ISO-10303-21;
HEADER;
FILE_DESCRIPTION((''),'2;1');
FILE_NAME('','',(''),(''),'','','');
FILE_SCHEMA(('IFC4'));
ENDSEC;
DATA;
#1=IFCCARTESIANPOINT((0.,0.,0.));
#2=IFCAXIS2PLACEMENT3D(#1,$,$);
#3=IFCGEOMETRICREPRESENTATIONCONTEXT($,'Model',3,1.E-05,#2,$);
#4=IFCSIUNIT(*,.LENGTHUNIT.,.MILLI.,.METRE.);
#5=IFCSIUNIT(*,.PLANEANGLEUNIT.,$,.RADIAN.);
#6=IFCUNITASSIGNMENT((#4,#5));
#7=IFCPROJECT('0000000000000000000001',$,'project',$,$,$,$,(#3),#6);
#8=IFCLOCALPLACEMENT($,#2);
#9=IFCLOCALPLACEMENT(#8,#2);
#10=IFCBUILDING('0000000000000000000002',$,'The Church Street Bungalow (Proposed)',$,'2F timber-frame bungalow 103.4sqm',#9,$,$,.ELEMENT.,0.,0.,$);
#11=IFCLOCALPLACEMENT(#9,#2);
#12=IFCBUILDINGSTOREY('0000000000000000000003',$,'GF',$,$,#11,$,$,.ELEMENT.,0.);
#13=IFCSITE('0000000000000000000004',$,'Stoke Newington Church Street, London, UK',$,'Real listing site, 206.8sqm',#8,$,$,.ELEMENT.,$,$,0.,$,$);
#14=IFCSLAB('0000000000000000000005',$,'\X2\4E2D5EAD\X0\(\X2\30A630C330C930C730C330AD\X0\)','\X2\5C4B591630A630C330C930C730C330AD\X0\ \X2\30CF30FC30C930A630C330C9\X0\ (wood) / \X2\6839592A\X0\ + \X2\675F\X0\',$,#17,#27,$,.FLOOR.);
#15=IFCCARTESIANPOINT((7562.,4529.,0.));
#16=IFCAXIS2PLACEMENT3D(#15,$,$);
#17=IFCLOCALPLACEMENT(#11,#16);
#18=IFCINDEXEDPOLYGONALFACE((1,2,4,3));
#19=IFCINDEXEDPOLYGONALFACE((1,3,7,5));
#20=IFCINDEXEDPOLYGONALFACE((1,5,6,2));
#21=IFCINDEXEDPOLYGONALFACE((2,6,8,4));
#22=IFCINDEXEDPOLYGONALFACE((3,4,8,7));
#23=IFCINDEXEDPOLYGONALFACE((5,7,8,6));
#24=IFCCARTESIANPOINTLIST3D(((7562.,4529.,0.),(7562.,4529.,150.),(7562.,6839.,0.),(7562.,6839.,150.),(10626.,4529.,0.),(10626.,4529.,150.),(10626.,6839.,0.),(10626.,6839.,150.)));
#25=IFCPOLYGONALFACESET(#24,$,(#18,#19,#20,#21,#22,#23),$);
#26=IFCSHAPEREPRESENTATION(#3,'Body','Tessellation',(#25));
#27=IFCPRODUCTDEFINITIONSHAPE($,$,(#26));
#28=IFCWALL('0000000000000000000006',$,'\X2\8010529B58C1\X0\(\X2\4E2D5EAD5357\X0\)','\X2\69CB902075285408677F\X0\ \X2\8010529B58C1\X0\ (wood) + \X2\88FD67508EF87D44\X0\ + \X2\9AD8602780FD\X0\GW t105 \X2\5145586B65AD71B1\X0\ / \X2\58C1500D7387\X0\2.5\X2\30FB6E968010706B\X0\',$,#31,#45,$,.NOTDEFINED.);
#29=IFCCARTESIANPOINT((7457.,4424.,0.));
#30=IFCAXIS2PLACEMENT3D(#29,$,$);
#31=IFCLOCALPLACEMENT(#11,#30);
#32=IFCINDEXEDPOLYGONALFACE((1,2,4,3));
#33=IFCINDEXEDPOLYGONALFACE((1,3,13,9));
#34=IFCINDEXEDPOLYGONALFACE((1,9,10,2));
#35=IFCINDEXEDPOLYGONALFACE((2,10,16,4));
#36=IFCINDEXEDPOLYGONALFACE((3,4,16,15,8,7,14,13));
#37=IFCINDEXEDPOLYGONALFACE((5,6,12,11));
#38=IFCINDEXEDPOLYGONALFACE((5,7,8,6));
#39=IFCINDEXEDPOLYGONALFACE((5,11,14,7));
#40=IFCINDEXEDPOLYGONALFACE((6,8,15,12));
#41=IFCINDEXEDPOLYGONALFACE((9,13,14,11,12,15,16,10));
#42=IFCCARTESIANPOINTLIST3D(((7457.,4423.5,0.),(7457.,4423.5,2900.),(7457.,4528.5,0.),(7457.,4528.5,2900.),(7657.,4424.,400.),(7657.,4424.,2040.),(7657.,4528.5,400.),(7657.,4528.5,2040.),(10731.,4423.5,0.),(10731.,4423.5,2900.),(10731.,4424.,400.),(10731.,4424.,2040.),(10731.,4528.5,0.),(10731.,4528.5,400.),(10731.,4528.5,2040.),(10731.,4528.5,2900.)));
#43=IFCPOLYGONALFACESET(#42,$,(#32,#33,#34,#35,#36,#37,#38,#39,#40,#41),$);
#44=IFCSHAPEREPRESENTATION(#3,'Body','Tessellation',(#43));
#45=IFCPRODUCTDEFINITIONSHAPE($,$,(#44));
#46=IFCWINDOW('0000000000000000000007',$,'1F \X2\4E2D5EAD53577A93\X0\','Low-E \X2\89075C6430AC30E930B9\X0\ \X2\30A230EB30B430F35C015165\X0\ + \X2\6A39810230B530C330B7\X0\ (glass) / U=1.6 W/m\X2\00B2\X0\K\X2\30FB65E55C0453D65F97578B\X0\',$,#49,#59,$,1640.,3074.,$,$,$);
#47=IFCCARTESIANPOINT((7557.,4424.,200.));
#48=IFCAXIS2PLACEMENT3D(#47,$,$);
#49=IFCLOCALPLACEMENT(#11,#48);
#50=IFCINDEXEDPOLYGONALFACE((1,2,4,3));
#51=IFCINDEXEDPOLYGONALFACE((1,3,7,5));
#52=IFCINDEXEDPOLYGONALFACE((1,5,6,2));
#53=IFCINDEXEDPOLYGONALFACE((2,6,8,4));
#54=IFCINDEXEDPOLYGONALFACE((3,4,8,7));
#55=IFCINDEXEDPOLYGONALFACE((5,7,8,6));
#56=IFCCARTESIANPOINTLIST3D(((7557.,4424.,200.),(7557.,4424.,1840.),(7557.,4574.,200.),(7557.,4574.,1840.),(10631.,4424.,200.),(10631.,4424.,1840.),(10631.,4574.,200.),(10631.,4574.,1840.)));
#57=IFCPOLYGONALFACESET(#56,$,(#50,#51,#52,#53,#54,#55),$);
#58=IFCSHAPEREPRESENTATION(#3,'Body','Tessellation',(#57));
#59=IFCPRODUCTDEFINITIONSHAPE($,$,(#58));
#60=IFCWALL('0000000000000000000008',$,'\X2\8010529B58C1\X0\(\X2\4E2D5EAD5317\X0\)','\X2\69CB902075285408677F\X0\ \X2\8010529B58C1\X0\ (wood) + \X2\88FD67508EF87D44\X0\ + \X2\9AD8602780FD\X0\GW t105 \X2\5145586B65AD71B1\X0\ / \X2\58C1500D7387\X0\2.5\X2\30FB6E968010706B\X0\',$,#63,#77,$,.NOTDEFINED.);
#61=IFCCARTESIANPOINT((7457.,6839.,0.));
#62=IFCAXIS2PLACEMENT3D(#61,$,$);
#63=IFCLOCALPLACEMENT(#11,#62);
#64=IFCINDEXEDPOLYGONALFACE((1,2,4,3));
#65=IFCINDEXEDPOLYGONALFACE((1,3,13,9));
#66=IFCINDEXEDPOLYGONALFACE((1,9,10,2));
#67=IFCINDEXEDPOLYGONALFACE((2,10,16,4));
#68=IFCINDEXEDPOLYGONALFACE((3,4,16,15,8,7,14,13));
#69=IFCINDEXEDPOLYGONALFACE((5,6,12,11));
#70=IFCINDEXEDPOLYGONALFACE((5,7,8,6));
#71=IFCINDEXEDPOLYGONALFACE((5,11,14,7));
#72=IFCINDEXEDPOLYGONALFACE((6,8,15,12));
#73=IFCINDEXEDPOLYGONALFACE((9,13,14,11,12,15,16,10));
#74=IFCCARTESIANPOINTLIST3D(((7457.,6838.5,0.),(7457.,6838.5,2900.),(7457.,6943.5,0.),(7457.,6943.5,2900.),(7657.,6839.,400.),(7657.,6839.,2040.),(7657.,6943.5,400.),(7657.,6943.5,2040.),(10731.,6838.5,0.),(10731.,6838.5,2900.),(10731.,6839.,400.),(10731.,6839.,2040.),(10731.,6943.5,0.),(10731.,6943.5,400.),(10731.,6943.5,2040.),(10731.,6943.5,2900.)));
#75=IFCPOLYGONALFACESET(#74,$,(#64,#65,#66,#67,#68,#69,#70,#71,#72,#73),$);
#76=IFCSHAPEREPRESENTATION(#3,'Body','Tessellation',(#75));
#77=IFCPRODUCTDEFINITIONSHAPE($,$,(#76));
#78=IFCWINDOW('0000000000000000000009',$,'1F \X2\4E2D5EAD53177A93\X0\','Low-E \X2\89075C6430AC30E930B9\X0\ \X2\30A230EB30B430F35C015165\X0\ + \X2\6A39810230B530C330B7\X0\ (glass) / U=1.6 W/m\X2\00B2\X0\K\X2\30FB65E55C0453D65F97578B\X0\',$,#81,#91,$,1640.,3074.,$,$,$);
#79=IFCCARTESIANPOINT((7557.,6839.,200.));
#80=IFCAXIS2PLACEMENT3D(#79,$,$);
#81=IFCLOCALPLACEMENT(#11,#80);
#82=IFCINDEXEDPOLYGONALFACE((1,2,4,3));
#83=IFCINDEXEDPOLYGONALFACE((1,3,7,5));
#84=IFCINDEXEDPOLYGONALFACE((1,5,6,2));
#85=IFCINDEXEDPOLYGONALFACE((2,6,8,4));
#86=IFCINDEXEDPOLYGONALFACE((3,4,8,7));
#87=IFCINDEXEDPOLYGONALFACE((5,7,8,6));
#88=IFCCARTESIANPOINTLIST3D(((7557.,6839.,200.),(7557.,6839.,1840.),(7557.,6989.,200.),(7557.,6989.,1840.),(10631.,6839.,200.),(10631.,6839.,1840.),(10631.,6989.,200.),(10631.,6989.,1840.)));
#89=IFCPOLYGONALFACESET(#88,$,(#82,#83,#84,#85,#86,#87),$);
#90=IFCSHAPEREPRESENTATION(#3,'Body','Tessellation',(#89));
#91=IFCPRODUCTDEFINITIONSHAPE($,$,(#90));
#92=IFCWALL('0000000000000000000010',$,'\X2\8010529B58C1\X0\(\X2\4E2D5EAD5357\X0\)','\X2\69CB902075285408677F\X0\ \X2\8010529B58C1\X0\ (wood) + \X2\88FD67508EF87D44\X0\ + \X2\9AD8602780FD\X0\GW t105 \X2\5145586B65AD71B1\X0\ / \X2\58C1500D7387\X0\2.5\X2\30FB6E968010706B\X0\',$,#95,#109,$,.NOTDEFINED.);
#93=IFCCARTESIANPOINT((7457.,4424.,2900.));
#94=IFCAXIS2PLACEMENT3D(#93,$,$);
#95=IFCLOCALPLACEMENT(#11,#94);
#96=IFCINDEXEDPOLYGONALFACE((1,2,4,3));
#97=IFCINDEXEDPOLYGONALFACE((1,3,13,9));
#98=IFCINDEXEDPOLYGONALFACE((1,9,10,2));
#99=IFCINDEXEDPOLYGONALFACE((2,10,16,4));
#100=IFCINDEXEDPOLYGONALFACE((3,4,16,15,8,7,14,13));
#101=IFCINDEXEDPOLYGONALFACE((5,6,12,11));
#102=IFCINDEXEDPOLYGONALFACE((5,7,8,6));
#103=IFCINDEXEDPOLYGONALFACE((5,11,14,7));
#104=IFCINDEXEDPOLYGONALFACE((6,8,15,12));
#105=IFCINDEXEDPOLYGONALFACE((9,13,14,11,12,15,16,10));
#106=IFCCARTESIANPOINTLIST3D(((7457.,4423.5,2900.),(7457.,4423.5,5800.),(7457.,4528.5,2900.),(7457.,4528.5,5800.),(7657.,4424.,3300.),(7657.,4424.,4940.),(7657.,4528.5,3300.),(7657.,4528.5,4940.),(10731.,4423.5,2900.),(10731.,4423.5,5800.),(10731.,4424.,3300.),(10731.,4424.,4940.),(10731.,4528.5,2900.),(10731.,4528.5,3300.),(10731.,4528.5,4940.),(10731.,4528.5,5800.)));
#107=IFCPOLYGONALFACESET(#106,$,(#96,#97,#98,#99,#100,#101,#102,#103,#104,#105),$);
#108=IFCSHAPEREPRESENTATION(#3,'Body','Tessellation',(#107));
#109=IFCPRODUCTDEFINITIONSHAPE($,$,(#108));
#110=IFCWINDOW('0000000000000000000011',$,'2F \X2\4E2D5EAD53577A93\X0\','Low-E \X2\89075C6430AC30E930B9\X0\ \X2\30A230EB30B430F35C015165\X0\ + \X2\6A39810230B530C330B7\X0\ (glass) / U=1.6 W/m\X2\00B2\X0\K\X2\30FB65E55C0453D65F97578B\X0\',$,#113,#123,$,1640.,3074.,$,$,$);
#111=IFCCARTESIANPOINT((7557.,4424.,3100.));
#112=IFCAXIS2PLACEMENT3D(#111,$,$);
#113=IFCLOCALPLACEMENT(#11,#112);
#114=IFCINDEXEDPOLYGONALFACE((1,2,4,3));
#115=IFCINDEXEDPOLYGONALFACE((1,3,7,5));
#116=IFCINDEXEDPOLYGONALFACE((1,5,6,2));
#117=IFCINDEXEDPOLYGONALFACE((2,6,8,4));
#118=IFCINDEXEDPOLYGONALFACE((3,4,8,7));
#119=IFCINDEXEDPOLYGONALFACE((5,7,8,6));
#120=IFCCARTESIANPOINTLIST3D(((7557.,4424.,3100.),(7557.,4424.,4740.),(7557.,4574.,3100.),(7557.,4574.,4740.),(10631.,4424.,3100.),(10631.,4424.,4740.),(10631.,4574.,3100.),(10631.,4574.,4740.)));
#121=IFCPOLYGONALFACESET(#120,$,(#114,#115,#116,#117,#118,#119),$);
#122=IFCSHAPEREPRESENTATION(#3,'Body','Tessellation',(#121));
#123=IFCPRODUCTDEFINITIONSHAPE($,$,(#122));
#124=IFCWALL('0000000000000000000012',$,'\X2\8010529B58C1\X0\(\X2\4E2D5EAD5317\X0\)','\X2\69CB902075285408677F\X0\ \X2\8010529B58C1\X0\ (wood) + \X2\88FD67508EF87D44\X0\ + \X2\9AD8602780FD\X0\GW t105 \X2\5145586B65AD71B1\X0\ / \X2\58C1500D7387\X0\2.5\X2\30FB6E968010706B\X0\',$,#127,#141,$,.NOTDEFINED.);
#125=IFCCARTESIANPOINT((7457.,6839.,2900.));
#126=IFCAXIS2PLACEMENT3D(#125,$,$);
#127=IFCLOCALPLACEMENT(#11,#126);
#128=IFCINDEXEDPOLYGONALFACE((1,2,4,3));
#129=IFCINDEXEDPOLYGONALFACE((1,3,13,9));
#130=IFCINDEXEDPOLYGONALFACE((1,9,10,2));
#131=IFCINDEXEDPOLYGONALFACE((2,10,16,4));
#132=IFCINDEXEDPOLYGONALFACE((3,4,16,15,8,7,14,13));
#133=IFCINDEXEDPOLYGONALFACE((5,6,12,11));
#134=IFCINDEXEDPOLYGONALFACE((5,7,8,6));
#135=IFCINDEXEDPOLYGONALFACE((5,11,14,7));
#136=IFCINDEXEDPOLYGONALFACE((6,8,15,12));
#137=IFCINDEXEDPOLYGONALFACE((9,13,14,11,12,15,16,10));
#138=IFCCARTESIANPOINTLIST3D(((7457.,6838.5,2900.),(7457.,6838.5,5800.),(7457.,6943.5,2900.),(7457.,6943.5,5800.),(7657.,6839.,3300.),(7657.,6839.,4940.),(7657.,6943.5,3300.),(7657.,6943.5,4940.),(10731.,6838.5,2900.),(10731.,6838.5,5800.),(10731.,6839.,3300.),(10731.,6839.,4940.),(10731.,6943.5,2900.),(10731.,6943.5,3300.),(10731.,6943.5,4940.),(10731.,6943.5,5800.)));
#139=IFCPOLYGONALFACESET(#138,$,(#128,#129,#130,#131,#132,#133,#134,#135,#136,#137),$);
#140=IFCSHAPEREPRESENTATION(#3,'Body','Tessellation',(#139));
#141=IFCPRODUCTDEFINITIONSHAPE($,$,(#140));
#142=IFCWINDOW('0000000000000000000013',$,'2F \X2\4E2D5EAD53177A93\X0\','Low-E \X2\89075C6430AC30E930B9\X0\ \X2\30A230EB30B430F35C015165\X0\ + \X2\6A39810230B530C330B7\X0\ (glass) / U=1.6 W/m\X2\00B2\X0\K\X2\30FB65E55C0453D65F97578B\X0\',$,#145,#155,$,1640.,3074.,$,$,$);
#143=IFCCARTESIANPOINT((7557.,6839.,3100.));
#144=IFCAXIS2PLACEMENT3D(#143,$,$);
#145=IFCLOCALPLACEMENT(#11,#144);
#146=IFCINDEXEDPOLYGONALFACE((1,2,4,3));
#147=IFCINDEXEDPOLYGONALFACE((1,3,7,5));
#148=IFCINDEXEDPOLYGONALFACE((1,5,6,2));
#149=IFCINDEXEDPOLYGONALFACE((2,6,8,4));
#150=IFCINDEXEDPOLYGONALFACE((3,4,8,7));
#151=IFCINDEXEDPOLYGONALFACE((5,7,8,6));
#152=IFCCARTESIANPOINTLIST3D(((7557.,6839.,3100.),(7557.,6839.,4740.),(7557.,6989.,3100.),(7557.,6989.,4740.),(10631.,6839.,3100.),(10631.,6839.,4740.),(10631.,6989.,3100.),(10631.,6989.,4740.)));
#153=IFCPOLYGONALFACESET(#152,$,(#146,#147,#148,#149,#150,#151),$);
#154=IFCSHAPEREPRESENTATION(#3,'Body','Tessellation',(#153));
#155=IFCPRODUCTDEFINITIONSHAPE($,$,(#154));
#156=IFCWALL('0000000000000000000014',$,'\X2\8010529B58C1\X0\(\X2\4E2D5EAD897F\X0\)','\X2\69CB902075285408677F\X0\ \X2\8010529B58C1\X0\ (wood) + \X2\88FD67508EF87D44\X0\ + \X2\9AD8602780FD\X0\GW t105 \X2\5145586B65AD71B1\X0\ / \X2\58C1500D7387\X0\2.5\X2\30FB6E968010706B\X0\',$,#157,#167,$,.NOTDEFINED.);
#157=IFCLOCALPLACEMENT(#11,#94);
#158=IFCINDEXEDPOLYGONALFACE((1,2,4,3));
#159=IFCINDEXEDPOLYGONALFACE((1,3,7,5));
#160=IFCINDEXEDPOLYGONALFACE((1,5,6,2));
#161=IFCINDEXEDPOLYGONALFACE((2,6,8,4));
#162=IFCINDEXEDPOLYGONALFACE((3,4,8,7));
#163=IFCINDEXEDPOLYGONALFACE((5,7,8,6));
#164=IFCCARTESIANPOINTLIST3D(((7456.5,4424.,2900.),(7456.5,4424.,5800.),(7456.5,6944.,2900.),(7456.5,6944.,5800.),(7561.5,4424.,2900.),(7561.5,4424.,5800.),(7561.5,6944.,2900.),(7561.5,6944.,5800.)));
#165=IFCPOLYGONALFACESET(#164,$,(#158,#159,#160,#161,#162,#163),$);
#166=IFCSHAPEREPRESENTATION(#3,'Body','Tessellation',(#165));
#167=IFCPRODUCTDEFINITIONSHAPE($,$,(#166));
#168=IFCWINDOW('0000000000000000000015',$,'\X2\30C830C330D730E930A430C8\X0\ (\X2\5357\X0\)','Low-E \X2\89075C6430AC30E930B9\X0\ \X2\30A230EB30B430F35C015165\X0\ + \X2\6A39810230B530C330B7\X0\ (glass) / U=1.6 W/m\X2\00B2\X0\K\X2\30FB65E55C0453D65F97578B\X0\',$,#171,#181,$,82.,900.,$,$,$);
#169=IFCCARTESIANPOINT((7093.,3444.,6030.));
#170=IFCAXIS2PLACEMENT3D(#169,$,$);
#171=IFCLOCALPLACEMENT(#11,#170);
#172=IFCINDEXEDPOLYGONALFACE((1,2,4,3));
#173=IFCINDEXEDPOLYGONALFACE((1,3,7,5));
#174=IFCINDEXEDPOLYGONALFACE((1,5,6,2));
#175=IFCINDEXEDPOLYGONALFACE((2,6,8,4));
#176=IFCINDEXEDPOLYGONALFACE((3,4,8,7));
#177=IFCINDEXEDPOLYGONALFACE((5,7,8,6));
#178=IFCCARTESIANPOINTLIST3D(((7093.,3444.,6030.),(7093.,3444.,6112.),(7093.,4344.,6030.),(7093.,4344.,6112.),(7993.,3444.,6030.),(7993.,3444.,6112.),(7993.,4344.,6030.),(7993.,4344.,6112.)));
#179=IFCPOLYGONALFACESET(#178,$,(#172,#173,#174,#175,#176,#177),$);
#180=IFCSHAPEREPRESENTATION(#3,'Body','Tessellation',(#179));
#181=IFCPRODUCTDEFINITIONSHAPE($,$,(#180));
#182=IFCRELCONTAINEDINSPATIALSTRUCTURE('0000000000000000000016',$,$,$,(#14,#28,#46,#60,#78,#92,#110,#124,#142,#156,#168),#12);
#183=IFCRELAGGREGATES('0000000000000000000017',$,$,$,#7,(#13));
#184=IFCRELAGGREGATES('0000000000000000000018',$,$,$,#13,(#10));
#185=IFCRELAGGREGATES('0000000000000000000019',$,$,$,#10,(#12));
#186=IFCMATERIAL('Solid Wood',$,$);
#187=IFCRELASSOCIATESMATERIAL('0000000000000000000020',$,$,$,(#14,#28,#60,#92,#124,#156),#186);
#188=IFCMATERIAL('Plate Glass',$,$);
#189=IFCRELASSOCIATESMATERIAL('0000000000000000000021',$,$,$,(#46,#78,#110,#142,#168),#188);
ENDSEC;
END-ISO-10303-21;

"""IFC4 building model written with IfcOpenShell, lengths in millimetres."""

from ifc_helpers import new_model, si_unit, frame, frame_2d, origin, place, context, project, spatial, rectangle, extrude, material, element, fill, save


model = new_model("IFC4")

# Units and contexts
model_context = context("Model", 3, precision=1e-05, world=origin())
ifc_project = project(units=[si_unit("LENGTHUNIT", "METRE", prefix="MILLI"), si_unit("PLANEANGLEUNIT", "RADIAN")], contexts=[model_context])

# Site, building, storey
site_placement = place(None, origin())
site = spatial("IfcSite", under=ifc_project, at=site_placement, Name="Stoke Newington Church Street, London, UK", ObjectType="Real listing site, 206.8sqm", CompositionType="ELEMENT", RefElevation=0.0)
building_placement = place(site_placement, origin())
building = spatial("IfcBuilding", under=site, at=building_placement, Name="The Church Street Bungalow (Proposed)", ObjectType="2F timber-frame bungalow 103.4sqm", CompositionType="ELEMENT", ElevationOfRefHeight=0.0, ElevationOfTerrain=0.0)
storey_placement = place(building_placement, origin())
storey = spatial("IfcBuildingStorey", under=building, at=storey_placement, Name="GF", CompositionType="ELEMENT", Elevation=0.0)

# Slab
ifc_material_1 = material(Name="Solid Wood")
slab_placement = place(storey_placement, frame((7562.0, 4529.0, 0.0)))
element("IfcSlab", 1, at=slab_placement, inside=storey, material=ifc_material_1, Name="中庭(ウッドデッキ)", Description="屋外ウッドデッキ ハードウッド (wood) / 根太 + 束", PredefinedType="FLOOR", context=model_context, shape_type="SweptSolid", body=[
    extrude(rectangle(XDim=3064.0, YDim=2310.0, at=frame_2d((1532.0, 1155.0))), frame((7562.0, 4529.0, 0.0)), (0.0, 0.0, 1.0), 150.0),
])

# Walls, openings, windows
wall_1_placement = place(storey_placement, frame((7457.0, 4424.0, 0.0)))
wall_1 = element("IfcWall", 2, at=wall_1_placement, inside=storey, material=ifc_material_1, Name="耐力壁(中庭南)", Description="構造用合板 耐力壁 (wood) + 製材軸組 + 高性能GW t105 充填断熱 / 壁倍率2.5・準耐火", PredefinedType="NOTDEFINED", context=model_context, shape_type="SweptSolid", body=[
    extrude(rectangle(XDim=3274.0, YDim=105.0, at=frame_2d((1637.0, 52.0))), frame((7457.0, 4424.0, 0.0)), (0.0, 0.0, 1.0), 2900.0),
])
opening_1_placement = place(storey_placement, frame((7557.0, 4424.0, 200.0)))
opening_1 = element("IfcOpeningElement", 3, at=opening_1_placement, cuts=wall_1, PredefinedType="NOTDEFINED", context=model_context, shape_type="SweptSolid", body=[
    extrude(rectangle(XDim=3074.0, YDim=150.0, at=frame_2d((1537.0, 75.0))), frame((7557.0, 4424.0, 200.0)), (0.0, 0.0, 1.0), 1640.0),
])
ifc_material_2 = material(Name="Plate Glass")
window_1_placement = place(storey_placement, frame((7557.0, 4424.0, 200.0)))
window_1 = element("IfcWindow", 4, at=window_1_placement, inside=storey, material=ifc_material_2, Name="1F 中庭南窓", Description="Low-E 複層ガラス アルゴン封入 + 樹脂サッシ (glass) / U=1.6 W/m²K・日射取得型", OverallHeight=1640.0, OverallWidth=3074.0, context=model_context, shape_type="SweptSolid", body=[
    extrude(rectangle(XDim=3074.0, YDim=150.0, at=frame_2d((1537.0, 75.0))), frame((7557.0, 4424.0, 200.0)), (0.0, 0.0, 1.0), 1640.0),
])
fill(opening_1, window_1)
wall_2_placement = place(storey_placement, frame((7457.0, 6839.0, 0.0)))
wall_2 = element("IfcWall", 5, at=wall_2_placement, inside=storey, material=ifc_material_1, Name="耐力壁(中庭北)", Description="構造用合板 耐力壁 (wood) + 製材軸組 + 高性能GW t105 充填断熱 / 壁倍率2.5・準耐火", PredefinedType="NOTDEFINED", context=model_context, shape_type="SweptSolid", body=[
    extrude(rectangle(XDim=3274.0, YDim=105.0, at=frame_2d((1637.0, 52.0))), frame((7457.0, 6839.0, 0.0)), (0.0, 0.0, 1.0), 2900.0),
])
opening_2_placement = place(storey_placement, frame((7557.0, 6839.0, 200.0)))
opening_2 = element("IfcOpeningElement", 6, at=opening_2_placement, cuts=wall_2, PredefinedType="NOTDEFINED", context=model_context, shape_type="SweptSolid", body=[
    extrude(rectangle(XDim=3074.0, YDim=150.0, at=frame_2d((1537.0, 75.0))), frame((7557.0, 6839.0, 200.0)), (0.0, 0.0, 1.0), 1640.0),
])
window_2_placement = place(storey_placement, frame((7557.0, 6839.0, 200.0)))
window_2 = element("IfcWindow", 7, at=window_2_placement, inside=storey, material=ifc_material_2, Name="1F 中庭北窓", Description="Low-E 複層ガラス アルゴン封入 + 樹脂サッシ (glass) / U=1.6 W/m²K・日射取得型", OverallHeight=1640.0, OverallWidth=3074.0, context=model_context, shape_type="SweptSolid", body=[
    extrude(rectangle(XDim=3074.0, YDim=150.0, at=frame_2d((1537.0, 75.0))), frame((7557.0, 6839.0, 200.0)), (0.0, 0.0, 1.0), 1640.0),
])
fill(opening_2, window_2)

# Walls, openings, windows
wall_3_placement = place(storey_placement, frame((7457.0, 4424.0, 2900.0)))
wall_3 = element("IfcWall", 8, at=wall_3_placement, inside=storey, material=ifc_material_1, Name="耐力壁(中庭南)", Description="構造用合板 耐力壁 (wood) + 製材軸組 + 高性能GW t105 充填断熱 / 壁倍率2.5・準耐火", PredefinedType="NOTDEFINED", context=model_context, shape_type="SweptSolid", body=[
    extrude(rectangle(XDim=3274.0, YDim=105.0, at=frame_2d((1637.0, 52.0))), frame((7457.0, 4424.0, 2900.0)), (0.0, 0.0, 1.0), 2900.0),
])
opening_3_placement = place(storey_placement, frame((7557.0, 4424.0, 3100.0)))
opening_3 = element("IfcOpeningElement", 9, at=opening_3_placement, cuts=wall_3, PredefinedType="NOTDEFINED", context=model_context, shape_type="SweptSolid", body=[
    extrude(rectangle(XDim=3074.0, YDim=150.0, at=frame_2d((1537.0, 75.0))), frame((7557.0, 4424.0, 3100.0)), (0.0, 0.0, 1.0), 1640.0),
])
window_3_placement = place(storey_placement, frame((7557.0, 4424.0, 3100.0)))
window_3 = element("IfcWindow", 10, at=window_3_placement, inside=storey, material=ifc_material_2, Name="2F 中庭南窓", Description="Low-E 複層ガラス アルゴン封入 + 樹脂サッシ (glass) / U=1.6 W/m²K・日射取得型", OverallHeight=1640.0, OverallWidth=3074.0, context=model_context, shape_type="SweptSolid", body=[
    extrude(rectangle(XDim=3074.0, YDim=150.0, at=frame_2d((1537.0, 75.0))), frame((7557.0, 4424.0, 3100.0)), (0.0, 0.0, 1.0), 1640.0),
])
fill(opening_3, window_3)
wall_4_placement = place(storey_placement, frame((7457.0, 6839.0, 2900.0)))
wall_4 = element("IfcWall", 11, at=wall_4_placement, inside=storey, material=ifc_material_1, Name="耐力壁(中庭北)", Description="構造用合板 耐力壁 (wood) + 製材軸組 + 高性能GW t105 充填断熱 / 壁倍率2.5・準耐火", PredefinedType="NOTDEFINED", context=model_context, shape_type="SweptSolid", body=[
    extrude(rectangle(XDim=3274.0, YDim=105.0, at=frame_2d((1637.0, 52.0))), frame((7457.0, 6839.0, 2900.0)), (0.0, 0.0, 1.0), 2900.0),
])
opening_4_placement = place(storey_placement, frame((7557.0, 6839.0, 3100.0)))
opening_4 = element("IfcOpeningElement", 12, at=opening_4_placement, cuts=wall_4, PredefinedType="NOTDEFINED", context=model_context, shape_type="SweptSolid", body=[
    extrude(rectangle(XDim=3074.0, YDim=150.0, at=frame_2d((1537.0, 75.0))), frame((7557.0, 6839.0, 3100.0)), (0.0, 0.0, 1.0), 1640.0),
])
window_4_placement = place(storey_placement, frame((7557.0, 6839.0, 3100.0)))
window_4 = element("IfcWindow", 13, at=window_4_placement, inside=storey, material=ifc_material_2, Name="2F 中庭北窓", Description="Low-E 複層ガラス アルゴン封入 + 樹脂サッシ (glass) / U=1.6 W/m²K・日射取得型", OverallHeight=1640.0, OverallWidth=3074.0, context=model_context, shape_type="SweptSolid", body=[
    extrude(rectangle(XDim=3074.0, YDim=150.0, at=frame_2d((1537.0, 75.0))), frame((7557.0, 6839.0, 3100.0)), (0.0, 0.0, 1.0), 1640.0),
])
fill(opening_4, window_4)

# Wall
wall_5_placement = place(storey_placement, frame((7457.0, 4424.0, 2900.0)))
element("IfcWall", 14, at=wall_5_placement, inside=storey, material=ifc_material_1, Name="耐力壁(中庭西)", Description="構造用合板 耐力壁 (wood) + 製材軸組 + 高性能GW t105 充填断熱 / 壁倍率2.5・準耐火", PredefinedType="NOTDEFINED", context=model_context, shape_type="SweptSolid", body=[
    extrude(rectangle(XDim=105.0, YDim=2520.0, at=frame_2d((52.0, 1260.0))), frame((7457.0, 4424.0, 2900.0)), (0.0, 0.0, 1.0), 2900.0),
])

# Window
window_5_placement = place(storey_placement, frame((7093.0, 3444.0, 6030.0)))
element("IfcWindow", 15, at=window_5_placement, inside=storey, material=ifc_material_2, Name="トップライト (南)", Description="Low-E 複層ガラス アルゴン封入 + 樹脂サッシ (glass) / U=1.6 W/m²K・日射取得型", OverallHeight=82.0, OverallWidth=900.0, context=model_context, shape_type="SweptSolid", body=[
    extrude(rectangle(XDim=900.0, YDim=900.0, at=frame_2d((450.0, 450.0))), frame((7093.0, 3444.0, 6030.0)), (0.0, 0.0, 1.0), 82.0),
])

save(model, "model.ifc")
